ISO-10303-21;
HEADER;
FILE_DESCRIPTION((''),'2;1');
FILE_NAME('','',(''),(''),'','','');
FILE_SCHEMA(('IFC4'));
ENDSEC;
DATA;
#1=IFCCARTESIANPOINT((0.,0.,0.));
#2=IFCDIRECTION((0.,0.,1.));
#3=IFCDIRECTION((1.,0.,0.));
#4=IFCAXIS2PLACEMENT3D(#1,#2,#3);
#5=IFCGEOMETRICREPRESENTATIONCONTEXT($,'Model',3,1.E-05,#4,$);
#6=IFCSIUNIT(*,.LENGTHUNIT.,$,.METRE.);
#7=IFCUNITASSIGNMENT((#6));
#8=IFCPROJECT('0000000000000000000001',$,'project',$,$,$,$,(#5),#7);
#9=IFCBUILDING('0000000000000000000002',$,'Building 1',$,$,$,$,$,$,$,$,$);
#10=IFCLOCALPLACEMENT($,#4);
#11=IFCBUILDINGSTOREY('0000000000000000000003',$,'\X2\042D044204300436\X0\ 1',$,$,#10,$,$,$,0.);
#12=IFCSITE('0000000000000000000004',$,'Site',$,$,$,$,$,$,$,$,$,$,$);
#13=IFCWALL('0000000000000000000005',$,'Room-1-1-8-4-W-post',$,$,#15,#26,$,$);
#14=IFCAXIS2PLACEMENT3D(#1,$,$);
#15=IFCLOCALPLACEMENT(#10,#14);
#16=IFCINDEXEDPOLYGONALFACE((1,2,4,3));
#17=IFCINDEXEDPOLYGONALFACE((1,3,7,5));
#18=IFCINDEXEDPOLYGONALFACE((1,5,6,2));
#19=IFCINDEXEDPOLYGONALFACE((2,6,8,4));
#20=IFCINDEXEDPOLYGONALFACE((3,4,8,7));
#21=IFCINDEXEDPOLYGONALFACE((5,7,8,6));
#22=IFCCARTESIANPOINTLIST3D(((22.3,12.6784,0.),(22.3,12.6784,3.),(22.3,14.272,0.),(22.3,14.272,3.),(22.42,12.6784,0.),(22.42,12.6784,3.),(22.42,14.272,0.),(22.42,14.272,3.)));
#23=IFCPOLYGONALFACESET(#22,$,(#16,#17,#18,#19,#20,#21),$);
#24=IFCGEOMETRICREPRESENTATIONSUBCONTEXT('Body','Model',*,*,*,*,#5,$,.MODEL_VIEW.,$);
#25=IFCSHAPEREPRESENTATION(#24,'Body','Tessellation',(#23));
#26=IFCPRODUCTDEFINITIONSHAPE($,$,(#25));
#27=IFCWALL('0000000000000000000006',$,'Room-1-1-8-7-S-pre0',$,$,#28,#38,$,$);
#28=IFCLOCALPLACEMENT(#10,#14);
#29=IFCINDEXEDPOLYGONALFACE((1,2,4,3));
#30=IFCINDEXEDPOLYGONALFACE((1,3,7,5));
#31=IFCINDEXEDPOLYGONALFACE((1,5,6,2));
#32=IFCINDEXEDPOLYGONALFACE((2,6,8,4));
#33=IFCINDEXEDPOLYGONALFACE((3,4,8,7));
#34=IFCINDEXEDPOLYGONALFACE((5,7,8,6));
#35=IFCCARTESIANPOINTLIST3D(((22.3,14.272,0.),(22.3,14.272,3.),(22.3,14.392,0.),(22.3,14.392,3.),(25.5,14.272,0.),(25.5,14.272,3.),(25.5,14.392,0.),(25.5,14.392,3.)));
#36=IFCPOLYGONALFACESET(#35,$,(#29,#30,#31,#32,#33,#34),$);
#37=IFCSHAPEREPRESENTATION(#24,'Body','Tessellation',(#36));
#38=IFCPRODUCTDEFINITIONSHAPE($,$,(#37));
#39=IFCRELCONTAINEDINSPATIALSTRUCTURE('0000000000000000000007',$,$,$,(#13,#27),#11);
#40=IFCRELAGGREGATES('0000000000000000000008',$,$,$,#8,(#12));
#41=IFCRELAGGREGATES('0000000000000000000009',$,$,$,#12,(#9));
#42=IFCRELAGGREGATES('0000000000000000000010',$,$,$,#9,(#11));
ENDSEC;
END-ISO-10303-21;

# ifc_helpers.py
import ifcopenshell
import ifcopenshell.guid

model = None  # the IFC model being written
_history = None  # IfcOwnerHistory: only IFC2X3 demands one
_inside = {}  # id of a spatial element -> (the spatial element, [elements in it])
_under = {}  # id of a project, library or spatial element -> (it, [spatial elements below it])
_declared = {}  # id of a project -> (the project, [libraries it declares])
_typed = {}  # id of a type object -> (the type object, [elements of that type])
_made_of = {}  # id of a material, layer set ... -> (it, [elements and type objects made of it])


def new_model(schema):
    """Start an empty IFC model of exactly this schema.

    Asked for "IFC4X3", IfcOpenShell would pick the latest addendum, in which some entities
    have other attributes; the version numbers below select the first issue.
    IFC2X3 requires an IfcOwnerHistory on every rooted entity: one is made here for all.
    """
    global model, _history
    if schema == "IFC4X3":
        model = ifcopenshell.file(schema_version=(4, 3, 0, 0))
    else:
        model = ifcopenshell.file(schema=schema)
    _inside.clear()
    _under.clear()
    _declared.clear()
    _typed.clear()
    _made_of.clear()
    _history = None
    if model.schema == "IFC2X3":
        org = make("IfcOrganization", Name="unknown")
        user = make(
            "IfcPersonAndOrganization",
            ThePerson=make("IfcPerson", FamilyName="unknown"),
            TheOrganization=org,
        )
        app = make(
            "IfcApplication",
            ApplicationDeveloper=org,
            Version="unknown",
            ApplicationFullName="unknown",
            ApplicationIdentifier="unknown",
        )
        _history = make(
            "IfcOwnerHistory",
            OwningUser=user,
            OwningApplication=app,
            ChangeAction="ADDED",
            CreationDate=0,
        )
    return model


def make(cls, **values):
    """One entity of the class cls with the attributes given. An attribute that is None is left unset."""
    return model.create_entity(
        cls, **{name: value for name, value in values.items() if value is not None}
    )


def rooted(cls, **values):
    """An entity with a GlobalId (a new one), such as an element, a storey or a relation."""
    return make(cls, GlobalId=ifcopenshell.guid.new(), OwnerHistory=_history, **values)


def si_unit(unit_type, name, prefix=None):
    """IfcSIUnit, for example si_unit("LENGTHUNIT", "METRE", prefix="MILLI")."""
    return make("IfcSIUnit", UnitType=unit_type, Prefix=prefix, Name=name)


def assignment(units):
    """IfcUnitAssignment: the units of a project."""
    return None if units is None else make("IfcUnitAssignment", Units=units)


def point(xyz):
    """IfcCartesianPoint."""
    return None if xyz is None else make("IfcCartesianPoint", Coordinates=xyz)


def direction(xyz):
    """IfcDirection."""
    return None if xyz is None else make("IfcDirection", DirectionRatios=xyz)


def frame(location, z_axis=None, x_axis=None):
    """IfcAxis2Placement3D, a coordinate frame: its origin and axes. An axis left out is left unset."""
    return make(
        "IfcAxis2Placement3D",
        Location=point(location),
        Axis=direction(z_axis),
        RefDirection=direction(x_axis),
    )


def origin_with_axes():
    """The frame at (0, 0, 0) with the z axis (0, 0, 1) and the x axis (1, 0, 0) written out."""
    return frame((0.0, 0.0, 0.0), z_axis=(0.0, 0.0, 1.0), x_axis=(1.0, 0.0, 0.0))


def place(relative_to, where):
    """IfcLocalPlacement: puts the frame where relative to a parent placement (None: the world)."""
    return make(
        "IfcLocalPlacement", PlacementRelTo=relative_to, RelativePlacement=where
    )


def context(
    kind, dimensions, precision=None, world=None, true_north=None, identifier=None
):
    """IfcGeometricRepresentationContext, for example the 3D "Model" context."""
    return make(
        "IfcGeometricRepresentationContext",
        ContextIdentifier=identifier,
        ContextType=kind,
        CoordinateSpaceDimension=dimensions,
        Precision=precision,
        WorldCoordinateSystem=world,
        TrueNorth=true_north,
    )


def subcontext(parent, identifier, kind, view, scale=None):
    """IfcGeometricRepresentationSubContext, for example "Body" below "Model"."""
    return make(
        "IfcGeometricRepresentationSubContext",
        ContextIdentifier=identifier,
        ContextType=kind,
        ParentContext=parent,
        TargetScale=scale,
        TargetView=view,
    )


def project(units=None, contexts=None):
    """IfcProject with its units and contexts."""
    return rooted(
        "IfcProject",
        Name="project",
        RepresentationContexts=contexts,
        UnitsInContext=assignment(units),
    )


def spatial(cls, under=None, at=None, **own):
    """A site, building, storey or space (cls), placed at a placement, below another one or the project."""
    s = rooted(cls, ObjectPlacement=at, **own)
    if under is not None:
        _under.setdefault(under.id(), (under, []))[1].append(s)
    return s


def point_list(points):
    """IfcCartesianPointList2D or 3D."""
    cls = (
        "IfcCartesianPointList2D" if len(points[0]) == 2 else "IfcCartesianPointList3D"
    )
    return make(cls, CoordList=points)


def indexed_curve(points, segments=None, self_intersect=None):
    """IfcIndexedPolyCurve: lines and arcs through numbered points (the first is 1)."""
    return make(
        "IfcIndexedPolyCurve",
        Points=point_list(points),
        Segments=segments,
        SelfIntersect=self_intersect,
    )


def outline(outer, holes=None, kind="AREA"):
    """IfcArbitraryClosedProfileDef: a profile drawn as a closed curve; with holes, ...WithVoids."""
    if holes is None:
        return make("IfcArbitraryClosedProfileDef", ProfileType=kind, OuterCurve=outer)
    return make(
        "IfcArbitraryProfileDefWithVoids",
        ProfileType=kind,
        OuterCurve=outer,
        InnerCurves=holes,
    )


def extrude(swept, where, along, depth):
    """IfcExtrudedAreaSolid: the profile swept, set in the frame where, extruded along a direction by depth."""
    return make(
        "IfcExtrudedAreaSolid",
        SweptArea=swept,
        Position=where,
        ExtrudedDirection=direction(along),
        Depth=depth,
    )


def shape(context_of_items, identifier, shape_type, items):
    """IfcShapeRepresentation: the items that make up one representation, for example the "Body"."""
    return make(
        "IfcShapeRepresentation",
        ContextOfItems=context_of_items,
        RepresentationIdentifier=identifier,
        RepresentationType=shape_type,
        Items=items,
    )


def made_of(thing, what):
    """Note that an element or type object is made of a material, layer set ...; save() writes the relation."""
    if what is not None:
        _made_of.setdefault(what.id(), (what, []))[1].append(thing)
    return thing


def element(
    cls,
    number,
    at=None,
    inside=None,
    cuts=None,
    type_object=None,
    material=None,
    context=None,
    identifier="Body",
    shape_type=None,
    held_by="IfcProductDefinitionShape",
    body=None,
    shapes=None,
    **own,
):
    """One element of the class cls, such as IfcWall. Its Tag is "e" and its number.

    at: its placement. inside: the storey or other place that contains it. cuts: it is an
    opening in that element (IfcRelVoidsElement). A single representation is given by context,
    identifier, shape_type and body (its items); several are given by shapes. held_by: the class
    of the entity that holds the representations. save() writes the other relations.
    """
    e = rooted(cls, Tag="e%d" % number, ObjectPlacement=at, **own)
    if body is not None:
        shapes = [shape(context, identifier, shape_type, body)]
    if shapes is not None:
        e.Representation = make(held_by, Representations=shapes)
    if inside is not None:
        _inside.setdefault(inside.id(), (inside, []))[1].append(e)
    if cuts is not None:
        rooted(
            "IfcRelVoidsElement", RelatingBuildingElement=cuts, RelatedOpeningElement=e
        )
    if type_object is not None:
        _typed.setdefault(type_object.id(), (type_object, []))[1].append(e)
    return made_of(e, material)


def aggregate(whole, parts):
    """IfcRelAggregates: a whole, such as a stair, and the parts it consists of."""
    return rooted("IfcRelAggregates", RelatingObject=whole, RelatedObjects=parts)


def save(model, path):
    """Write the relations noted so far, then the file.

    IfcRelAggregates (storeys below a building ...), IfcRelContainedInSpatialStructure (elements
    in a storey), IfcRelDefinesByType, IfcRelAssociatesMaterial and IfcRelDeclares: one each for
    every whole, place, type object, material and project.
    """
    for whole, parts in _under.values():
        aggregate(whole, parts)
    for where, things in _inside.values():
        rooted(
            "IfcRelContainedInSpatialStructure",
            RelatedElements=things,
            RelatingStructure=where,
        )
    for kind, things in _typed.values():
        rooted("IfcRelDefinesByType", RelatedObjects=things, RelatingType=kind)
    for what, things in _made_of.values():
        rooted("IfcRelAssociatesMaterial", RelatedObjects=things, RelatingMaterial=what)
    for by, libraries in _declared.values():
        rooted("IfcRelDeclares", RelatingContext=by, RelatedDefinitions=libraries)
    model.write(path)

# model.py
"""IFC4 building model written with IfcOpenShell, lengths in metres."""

from ifc_helpers import new_model, si_unit, frame, origin_with_axes, place, context, subcontext, project, spatial, indexed_curve, outline, extrude, element, save


model = new_model("IFC4")

# Units and contexts
model_context = context("Model", 3, precision=1e-05, world=origin_with_axes())
body_context = subcontext(model_context, "Body", "Model", "MODEL_VIEW")
ifc_project = project(units=[si_unit("LENGTHUNIT", "METRE")], contexts=[model_context])

# Site, building, storey
site = spatial("IfcSite", under=ifc_project, Name="Site")
building = spatial("IfcBuilding", under=site, Name="Building 1")
storey_placement = place(None, origin_with_axes())
storey = spatial("IfcBuildingStorey", under=building, at=storey_placement, Name="Этаж 1", Elevation=0.0)

# Walls
wall_1_placement = place(storey_placement, frame((22.3, 14.272, 0.0), z_axis=(0.0, 0.0, 1.0), x_axis=(0.0, -1.0, 0.0)))
element("IfcWall", 1, at=wall_1_placement, inside=storey, Name="Room-1-1-8-4-W-post", context=body_context, shape_type="SweptSolid", body=[
    extrude(outline(indexed_curve([(0.0, 0.0), (0.0, 0.12), (1.5936, 0.12), (1.5936, 0.0), (0.0, 0.0)], self_intersect=False)), origin_with_axes(), (0.0, 0.0, 1.0), 3.0),
])
wall_2_placement = place(storey_placement, frame((22.3, 14.272, 0.0), z_axis=(0.0, 0.0, 1.0), x_axis=(1.0, 0.0, 0.0)))
element("IfcWall", 2, at=wall_2_placement, inside=storey, Name="Room-1-1-8-7-S-pre0", context=body_context, shape_type="SweptSolid", body=[
    extrude(outline(indexed_curve([(0.0, 0.0), (0.0, 0.12), (3.2, 0.12), (3.2, 0.0), (0.0, 0.0)], self_intersect=False)), origin_with_axes(), (0.0, 0.0, 1.0), 3.0),
])

save(model, "model.ifc")
